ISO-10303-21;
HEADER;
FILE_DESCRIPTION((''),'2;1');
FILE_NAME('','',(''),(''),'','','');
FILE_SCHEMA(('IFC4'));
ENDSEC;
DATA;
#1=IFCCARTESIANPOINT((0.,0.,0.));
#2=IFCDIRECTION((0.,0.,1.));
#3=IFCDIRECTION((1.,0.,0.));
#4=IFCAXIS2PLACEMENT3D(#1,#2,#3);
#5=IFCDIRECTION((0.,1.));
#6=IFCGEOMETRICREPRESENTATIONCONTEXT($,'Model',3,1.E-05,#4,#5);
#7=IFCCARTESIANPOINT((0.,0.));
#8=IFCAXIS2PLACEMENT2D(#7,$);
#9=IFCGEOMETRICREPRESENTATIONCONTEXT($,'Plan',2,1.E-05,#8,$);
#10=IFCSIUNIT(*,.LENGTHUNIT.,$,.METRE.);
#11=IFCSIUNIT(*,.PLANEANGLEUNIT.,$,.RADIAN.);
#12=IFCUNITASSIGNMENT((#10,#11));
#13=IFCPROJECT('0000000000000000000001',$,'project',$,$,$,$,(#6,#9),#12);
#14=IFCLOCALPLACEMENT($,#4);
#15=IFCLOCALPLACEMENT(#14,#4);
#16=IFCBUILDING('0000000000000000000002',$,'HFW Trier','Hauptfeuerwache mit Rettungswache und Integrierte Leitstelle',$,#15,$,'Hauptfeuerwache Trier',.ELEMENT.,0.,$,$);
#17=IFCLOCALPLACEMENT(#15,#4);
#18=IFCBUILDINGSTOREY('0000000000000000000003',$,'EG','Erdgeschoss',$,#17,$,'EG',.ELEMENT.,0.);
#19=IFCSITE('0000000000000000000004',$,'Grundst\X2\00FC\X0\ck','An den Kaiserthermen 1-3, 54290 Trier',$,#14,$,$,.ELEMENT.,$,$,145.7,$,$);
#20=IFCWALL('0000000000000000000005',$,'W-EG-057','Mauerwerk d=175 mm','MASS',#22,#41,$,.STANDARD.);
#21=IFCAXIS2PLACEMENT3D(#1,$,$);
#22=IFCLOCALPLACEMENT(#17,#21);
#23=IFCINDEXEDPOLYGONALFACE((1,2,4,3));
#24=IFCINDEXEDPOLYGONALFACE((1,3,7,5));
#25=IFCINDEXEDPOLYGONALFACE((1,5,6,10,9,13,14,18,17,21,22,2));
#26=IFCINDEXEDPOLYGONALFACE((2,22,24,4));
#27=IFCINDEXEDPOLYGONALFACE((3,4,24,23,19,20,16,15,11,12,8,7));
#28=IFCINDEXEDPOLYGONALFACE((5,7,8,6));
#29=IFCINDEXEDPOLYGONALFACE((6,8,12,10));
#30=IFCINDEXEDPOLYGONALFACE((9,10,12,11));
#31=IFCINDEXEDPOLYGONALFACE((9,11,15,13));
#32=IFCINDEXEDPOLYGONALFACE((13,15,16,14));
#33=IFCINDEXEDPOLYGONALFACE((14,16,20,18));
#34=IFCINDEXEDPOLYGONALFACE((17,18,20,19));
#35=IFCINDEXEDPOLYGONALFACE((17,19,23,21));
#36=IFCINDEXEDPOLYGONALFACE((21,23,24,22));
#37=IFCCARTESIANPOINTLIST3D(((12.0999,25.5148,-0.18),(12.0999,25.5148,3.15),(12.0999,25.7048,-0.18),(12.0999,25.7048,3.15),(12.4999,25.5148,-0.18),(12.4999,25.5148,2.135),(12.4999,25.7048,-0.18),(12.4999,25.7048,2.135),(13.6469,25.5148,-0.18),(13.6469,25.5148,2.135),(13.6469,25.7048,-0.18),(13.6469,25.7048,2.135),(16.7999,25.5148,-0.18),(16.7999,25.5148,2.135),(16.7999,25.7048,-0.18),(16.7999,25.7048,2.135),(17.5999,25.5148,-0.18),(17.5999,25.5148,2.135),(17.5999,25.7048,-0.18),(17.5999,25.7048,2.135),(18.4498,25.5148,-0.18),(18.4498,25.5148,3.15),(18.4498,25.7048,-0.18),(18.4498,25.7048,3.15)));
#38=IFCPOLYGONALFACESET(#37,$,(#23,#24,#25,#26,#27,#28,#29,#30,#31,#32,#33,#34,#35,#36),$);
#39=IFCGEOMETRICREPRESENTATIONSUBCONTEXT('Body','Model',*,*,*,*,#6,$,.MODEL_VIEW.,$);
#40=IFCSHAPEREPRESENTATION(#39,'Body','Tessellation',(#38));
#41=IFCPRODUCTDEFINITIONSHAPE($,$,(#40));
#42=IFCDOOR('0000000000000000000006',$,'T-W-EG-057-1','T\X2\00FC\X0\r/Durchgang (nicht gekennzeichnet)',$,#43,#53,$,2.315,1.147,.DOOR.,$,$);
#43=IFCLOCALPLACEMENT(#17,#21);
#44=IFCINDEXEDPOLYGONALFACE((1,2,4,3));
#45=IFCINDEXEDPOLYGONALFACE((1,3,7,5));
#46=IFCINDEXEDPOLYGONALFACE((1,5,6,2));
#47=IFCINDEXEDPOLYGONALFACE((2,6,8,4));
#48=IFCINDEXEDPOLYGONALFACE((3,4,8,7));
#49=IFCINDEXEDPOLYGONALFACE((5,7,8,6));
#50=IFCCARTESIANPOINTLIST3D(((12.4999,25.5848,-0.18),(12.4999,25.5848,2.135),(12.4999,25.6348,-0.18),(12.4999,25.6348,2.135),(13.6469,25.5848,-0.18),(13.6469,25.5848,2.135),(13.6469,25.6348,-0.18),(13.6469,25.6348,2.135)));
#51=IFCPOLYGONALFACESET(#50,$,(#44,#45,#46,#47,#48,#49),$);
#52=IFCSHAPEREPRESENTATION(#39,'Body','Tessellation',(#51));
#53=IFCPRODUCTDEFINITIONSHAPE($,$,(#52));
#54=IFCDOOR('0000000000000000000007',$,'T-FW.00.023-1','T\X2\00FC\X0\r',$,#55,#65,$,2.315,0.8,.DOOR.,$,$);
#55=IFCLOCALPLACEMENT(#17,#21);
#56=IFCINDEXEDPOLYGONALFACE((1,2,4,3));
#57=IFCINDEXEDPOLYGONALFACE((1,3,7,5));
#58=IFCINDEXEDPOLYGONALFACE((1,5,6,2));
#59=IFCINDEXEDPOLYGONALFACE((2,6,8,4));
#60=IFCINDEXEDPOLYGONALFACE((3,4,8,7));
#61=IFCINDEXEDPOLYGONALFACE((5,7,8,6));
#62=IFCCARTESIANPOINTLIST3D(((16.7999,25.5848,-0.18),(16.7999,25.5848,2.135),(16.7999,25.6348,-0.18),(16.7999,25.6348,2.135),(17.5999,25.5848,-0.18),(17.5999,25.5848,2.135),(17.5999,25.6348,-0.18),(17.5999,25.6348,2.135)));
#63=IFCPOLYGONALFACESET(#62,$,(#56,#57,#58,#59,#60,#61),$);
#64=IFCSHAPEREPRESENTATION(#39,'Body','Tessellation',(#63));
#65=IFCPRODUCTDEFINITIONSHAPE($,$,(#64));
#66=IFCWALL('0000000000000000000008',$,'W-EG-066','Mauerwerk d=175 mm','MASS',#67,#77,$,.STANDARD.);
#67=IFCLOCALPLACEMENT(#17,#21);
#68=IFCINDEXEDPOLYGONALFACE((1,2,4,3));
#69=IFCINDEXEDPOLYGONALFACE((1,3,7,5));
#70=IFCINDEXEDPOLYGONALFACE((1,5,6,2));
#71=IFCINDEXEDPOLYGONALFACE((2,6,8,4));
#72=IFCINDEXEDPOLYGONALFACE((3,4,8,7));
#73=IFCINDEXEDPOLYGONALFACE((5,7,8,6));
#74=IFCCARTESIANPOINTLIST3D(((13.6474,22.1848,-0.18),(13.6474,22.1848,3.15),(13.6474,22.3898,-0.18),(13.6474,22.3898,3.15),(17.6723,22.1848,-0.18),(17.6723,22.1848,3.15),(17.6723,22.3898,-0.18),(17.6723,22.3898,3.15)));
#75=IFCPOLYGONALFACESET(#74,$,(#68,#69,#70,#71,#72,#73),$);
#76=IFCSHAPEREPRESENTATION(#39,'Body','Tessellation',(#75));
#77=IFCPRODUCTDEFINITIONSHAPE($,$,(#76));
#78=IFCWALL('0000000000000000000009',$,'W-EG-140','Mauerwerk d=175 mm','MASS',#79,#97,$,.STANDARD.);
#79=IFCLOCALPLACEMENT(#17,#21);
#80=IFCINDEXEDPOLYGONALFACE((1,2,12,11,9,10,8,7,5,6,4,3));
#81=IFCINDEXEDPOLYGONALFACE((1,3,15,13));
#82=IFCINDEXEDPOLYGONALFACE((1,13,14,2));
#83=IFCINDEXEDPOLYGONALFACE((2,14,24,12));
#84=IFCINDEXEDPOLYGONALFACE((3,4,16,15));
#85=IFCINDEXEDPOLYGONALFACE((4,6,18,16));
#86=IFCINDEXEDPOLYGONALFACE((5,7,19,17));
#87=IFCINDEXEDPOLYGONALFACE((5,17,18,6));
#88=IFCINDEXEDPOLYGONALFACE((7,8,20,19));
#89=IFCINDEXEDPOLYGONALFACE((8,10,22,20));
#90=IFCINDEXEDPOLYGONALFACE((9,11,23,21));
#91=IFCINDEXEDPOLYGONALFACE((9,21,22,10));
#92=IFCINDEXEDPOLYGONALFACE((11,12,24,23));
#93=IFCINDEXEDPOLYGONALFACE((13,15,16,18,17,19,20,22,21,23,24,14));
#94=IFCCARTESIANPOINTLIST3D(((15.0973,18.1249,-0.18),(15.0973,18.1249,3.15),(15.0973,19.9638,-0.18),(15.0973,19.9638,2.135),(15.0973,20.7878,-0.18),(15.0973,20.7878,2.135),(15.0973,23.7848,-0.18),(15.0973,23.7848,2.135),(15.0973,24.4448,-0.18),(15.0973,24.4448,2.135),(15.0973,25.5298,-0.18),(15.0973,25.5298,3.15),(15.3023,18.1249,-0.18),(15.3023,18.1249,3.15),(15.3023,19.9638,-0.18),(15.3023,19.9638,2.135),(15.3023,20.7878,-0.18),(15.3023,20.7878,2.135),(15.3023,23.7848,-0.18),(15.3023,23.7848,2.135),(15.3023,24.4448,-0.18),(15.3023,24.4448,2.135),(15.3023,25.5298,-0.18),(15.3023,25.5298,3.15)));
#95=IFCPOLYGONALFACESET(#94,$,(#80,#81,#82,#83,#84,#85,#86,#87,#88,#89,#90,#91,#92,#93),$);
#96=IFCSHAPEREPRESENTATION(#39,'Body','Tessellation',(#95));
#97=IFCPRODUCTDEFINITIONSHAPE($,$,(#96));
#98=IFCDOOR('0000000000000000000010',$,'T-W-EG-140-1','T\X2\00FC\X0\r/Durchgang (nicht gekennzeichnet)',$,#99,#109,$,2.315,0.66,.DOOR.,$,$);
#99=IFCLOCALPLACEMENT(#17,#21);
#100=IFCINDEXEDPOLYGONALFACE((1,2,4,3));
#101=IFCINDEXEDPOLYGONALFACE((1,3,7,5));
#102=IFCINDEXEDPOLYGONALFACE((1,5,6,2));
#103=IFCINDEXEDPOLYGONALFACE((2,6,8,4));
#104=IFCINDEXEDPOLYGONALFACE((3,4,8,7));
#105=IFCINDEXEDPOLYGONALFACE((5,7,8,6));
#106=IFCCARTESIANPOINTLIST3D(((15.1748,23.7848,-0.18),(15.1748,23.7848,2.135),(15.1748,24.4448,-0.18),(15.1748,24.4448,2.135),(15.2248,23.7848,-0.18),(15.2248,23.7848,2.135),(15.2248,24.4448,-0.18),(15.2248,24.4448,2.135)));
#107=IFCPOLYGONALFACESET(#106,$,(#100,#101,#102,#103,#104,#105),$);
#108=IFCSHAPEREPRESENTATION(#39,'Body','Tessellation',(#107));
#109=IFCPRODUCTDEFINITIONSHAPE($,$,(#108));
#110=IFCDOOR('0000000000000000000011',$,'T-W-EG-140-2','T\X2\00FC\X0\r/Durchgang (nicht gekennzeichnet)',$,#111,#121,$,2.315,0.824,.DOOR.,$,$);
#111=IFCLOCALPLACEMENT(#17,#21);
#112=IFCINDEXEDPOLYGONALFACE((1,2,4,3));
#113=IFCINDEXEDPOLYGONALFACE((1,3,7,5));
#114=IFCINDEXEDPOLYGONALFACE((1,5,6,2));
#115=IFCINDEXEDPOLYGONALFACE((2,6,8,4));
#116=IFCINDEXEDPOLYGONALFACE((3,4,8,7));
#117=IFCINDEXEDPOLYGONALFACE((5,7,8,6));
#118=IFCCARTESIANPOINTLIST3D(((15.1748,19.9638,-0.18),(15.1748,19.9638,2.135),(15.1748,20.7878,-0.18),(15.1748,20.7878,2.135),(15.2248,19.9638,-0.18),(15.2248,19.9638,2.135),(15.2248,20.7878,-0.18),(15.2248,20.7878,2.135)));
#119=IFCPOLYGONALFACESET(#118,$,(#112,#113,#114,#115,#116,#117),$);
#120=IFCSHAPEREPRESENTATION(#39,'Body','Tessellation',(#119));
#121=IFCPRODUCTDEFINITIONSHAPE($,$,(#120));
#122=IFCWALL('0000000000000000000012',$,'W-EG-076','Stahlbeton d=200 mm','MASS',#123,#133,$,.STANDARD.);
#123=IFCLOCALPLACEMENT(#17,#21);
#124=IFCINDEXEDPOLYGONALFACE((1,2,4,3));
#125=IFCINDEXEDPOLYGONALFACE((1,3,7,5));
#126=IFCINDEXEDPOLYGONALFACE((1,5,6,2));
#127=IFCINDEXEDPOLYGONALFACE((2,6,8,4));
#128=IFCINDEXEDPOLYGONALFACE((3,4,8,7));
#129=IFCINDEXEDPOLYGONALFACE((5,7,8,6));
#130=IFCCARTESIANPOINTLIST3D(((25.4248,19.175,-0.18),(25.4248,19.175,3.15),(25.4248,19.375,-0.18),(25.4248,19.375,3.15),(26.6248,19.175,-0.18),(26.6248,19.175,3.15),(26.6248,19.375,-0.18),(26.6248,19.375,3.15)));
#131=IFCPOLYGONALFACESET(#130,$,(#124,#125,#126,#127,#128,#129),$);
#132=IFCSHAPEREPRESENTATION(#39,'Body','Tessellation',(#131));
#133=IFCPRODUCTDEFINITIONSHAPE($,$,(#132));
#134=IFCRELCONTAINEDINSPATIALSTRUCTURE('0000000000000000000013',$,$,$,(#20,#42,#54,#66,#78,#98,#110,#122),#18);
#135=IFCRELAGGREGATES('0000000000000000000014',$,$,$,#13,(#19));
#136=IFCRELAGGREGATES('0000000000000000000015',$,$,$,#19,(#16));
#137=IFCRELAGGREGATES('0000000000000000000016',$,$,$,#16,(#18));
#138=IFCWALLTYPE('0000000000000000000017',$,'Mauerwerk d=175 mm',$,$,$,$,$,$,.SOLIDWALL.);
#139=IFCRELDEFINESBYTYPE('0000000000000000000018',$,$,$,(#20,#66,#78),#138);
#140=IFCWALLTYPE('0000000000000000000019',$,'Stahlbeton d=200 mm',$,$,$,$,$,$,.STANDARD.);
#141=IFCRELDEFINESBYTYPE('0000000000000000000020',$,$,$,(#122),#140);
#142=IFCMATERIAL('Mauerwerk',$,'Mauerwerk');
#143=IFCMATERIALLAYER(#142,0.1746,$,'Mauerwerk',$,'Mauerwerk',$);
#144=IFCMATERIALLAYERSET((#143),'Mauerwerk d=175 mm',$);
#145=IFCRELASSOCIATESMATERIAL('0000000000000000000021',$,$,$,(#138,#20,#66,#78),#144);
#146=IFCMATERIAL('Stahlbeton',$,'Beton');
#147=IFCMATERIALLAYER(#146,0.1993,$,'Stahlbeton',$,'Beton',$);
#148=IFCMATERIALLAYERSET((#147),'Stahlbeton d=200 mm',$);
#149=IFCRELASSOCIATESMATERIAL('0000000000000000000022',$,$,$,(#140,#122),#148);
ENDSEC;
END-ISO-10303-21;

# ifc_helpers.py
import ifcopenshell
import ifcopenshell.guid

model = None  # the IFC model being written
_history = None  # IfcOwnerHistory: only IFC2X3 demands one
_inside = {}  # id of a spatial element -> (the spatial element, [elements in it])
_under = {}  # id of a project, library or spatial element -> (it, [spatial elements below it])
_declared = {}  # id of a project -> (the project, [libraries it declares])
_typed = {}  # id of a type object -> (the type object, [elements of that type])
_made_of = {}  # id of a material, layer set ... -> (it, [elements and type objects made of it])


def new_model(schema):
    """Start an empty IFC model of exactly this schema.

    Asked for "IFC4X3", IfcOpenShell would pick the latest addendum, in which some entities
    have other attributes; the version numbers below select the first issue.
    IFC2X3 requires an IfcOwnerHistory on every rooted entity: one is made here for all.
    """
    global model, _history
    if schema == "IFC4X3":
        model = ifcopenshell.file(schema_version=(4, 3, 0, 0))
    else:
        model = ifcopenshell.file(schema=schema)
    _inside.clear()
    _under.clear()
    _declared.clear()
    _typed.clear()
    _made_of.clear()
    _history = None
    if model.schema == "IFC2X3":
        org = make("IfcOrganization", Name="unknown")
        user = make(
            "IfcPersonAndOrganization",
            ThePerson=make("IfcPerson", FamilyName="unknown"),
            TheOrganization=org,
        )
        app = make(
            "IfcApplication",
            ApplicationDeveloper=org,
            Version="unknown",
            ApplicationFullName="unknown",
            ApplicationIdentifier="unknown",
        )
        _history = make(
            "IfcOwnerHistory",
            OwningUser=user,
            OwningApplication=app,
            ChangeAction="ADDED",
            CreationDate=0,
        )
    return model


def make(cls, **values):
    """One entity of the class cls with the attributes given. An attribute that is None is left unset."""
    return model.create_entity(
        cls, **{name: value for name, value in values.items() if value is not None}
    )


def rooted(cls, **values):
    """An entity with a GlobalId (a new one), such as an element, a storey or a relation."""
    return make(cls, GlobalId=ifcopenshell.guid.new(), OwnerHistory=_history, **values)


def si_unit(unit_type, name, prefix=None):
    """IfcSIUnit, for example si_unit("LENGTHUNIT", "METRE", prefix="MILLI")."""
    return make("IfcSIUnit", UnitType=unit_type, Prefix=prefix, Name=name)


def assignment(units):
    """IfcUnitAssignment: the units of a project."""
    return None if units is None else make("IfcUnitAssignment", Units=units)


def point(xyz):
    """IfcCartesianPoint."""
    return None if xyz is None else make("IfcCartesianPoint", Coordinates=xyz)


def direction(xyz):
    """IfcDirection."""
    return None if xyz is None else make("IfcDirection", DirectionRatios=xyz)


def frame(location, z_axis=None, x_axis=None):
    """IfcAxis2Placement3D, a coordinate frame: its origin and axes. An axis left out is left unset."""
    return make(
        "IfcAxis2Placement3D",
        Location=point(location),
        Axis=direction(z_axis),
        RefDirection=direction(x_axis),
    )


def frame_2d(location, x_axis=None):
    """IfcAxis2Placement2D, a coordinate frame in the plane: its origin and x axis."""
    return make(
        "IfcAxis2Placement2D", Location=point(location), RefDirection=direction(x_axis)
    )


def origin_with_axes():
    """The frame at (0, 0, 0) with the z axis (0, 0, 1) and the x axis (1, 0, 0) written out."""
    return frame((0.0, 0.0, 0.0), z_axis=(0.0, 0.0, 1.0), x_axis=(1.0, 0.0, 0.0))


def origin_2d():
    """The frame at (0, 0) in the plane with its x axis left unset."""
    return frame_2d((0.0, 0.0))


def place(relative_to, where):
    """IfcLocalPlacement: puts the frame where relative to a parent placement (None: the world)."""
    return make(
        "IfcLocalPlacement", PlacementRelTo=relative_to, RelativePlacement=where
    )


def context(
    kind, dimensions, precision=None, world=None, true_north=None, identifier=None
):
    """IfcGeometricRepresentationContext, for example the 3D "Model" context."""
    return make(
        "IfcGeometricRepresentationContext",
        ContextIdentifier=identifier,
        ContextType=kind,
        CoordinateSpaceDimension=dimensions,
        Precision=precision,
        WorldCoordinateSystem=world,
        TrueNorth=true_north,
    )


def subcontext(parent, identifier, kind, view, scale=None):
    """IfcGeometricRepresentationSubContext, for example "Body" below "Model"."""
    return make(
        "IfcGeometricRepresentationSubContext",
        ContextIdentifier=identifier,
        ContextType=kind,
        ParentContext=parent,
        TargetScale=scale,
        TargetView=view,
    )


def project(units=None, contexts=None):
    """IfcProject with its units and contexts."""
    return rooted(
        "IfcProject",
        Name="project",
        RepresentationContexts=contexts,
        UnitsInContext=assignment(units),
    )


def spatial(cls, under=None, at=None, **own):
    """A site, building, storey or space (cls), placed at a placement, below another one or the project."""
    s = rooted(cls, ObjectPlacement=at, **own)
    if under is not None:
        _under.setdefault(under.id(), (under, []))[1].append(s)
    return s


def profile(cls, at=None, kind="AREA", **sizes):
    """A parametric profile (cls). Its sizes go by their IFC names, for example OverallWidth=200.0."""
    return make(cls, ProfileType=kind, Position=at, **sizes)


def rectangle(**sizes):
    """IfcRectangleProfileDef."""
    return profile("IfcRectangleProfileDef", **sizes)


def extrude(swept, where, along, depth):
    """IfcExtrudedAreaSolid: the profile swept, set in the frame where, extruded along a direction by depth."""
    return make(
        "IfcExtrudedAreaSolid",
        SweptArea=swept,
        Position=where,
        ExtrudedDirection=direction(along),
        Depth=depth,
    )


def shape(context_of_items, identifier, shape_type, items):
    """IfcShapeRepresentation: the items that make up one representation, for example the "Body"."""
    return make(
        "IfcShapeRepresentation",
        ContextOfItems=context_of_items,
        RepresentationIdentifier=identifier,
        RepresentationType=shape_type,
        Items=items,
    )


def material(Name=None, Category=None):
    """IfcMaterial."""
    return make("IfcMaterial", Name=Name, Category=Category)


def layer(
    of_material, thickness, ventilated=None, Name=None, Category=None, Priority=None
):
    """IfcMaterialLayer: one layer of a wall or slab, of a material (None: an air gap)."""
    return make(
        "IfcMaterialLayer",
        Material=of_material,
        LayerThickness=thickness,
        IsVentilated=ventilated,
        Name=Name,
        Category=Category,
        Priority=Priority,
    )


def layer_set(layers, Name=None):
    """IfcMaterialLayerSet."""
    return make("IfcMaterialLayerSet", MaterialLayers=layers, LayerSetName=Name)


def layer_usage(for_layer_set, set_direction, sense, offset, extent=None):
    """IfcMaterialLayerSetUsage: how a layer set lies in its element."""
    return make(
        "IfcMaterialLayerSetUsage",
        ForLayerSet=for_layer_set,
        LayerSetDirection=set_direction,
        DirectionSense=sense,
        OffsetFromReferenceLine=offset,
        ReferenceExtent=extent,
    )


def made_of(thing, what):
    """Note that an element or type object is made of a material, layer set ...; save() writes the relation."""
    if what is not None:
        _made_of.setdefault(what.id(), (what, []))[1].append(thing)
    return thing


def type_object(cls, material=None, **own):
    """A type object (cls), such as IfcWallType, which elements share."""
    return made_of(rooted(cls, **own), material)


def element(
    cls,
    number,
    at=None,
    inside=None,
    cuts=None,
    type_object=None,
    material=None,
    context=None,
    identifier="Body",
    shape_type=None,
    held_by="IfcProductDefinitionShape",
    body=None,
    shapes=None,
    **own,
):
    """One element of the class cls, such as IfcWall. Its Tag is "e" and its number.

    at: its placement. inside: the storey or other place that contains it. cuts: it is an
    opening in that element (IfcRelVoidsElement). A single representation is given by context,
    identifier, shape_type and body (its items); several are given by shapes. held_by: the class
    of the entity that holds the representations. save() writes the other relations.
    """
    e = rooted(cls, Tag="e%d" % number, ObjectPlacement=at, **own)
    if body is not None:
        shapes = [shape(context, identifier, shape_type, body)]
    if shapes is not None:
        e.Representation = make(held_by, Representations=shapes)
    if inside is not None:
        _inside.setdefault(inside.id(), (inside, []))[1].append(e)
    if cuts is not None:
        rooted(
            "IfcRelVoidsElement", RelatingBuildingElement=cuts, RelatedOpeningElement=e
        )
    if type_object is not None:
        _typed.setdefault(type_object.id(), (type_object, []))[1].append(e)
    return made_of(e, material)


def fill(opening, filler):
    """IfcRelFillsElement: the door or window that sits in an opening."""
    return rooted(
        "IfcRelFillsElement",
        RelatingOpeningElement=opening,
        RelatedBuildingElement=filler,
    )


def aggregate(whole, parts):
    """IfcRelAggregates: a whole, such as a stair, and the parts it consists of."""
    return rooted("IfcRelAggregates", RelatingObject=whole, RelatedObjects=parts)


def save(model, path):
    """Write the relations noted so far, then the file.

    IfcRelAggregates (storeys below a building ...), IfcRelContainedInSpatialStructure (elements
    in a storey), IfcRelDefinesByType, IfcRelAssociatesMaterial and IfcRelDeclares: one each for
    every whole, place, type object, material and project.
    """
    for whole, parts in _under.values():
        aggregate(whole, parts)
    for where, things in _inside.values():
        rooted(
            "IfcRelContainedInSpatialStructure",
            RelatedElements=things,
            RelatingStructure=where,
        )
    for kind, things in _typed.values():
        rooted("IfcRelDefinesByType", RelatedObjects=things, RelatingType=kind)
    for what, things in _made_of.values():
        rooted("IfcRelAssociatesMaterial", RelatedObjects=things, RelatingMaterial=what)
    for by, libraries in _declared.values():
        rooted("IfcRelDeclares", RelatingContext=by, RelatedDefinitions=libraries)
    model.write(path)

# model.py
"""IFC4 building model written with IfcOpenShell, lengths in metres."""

from ifc_helpers import new_model, si_unit, direction, frame, frame_2d, origin_with_axes, origin_2d, place, context, subcontext, project, spatial, rectangle, extrude, material, layer, layer_set, layer_usage, type_object, element, fill, save


model = new_model("IFC4")

# Units and contexts
model_context = context("Model", 3, precision=1e-05, world=origin_with_axes(), true_north=direction((0.0, 1.0)))
plan_context = context("Plan", 2, precision=1e-05, world=origin_2d())
body_context = subcontext(model_context, "Body", "Model", "MODEL_VIEW")
ifc_project = project(units=[si_unit("LENGTHUNIT", "METRE"), si_unit("PLANEANGLEUNIT", "RADIAN")], contexts=[model_context, plan_context])

# Site, building, storey
site_placement = place(None, origin_with_axes())
site = spatial("IfcSite", under=ifc_project, at=site_placement, Name="Grundstück", Description="An den Kaiserthermen 1-3, 54290 Trier", CompositionType="ELEMENT", RefElevation=145.7)
building_placement = place(site_placement, origin_with_axes())
building = spatial("IfcBuilding", under=site, at=building_placement, Name="HFW Trier", Description="Hauptfeuerwache mit Rettungswache und Integrierte Leitstelle", LongName="Hauptfeuerwache Trier", CompositionType="ELEMENT", ElevationOfRefHeight=0.0)
storey_placement = place(building_placement, origin_with_axes())
storey = spatial("IfcBuildingStorey", under=building, at=storey_placement, Name="EG", Description="Erdgeschoss", LongName="EG", CompositionType="ELEMENT", Elevation=0.0)

# Shared definitions
ifc_material_1 = material(Name="Stahlbeton", Category="Beton")

# Wall, openings, doors
ifc_material_2 = material(Name="Mauerwerk", Category="Mauerwerk")
ifc_layer_1 = layer(ifc_material_2, 0.1746, Name="Mauerwerk", Category="Mauerwerk")
ifc_layer_set_1 = layer_set([ifc_layer_1], Name="Mauerwerk d=175 mm")
ifc_layer_usage_1 = layer_usage(ifc_layer_set_1, "AXIS2", "POSITIVE", -0.095)
wall_type_1 = type_object("IfcWallType", Name="Mauerwerk d=175 mm", PredefinedType="SOLIDWALL", material=ifc_layer_set_1)
wall_1_placement = place(storey_placement, frame((12.0999, 25.6098, -0.18), z_axis=(0.0, 0.0, 1.0), x_axis=(1.0, 0.0, 0.0)))
wall_1 = element("IfcWall", 1, at=wall_1_placement, inside=storey, type_object=wall_type_1, material=ifc_layer_usage_1, Name="W-EG-057", Description="Mauerwerk d=175 mm", ObjectType="MASS", PredefinedType="STANDARD", context=body_context, shape_type="SweptSolid", body=[
    extrude(rectangle(XDim=6.3499, YDim=0.19, at=frame_2d((3.1749, 0.0))), origin_with_axes(), (0.0, 0.0, 1.0), 3.33),
])
opening_1_placement = place(wall_1_placement, frame((0.4, 0.0, 0.0), z_axis=(0.0, 0.0, 1.0), x_axis=(1.0, 0.0, 0.0)))
opening_1 = element("IfcOpeningElement", 2, at=opening_1_placement, cuts=wall_1, PredefinedType="OPENING", context=body_context, shape_type="SweptSolid", body=[
    extrude(rectangle(XDim=1.147, YDim=0.29, at=frame_2d((0.5735, 0.0))), origin_with_axes(), (0.0, 0.0, 1.0), 2.315),
])
opening_2_placement = place(wall_1_placement, frame((4.7, 0.0, 0.0), z_axis=(0.0, 0.0, 1.0), x_axis=(1.0, 0.0, 0.0)))
opening_2 = element("IfcOpeningElement", 3, at=opening_2_placement, cuts=wall_1, PredefinedType="OPENING", context=body_context, shape_type="SweptSolid", body=[
    extrude(rectangle(XDim=0.8, YDim=0.29, at=frame_2d((0.4, 0.0))), origin_with_axes(), (0.0, 0.0, 1.0), 2.315),
])
door_1_placement = place(wall_1_placement, frame((0.4, 0.0, 0.0), z_axis=(0.0, 0.0, 1.0), x_axis=(1.0, 0.0, 0.0)))
door_1 = element("IfcDoor", 4, at=door_1_placement, inside=storey, Name="T-W-EG-057-1", Description="Tür/Durchgang (nicht gekennzeichnet)", OverallHeight=2.315, OverallWidth=1.147, PredefinedType="DOOR", context=body_context, shape_type="SweptSolid", body=[
    extrude(rectangle(XDim=1.147, YDim=0.05, at=frame_2d((0.5735, 0.0))), origin_with_axes(), (0.0, 0.0, 1.0), 2.315),
])
fill(opening_1, door_1)
door_2_placement = place(wall_1_placement, frame((4.7, 0.0, 0.0), z_axis=(0.0, 0.0, 1.0), x_axis=(1.0, 0.0, 0.0)))
door_2 = element("IfcDoor", 5, at=door_2_placement, inside=storey, Name="T-FW.00.023-1", Description="Tür", OverallHeight=2.315, OverallWidth=0.8, PredefinedType="DOOR", context=body_context, shape_type="SweptSolid", body=[
    extrude(rectangle(XDim=0.8, YDim=0.05, at=frame_2d((0.4, 0.0))), origin_with_axes(), (0.0, 0.0, 1.0), 2.315),
])
fill(opening_2, door_2)

# Wall
ifc_layer_usage_2 = layer_usage(ifc_layer_set_1, "AXIS2", "POSITIVE", -0.1025)
wall_2_placement = place(storey_placement, frame((13.6474, 22.2873, -0.18), z_axis=(0.0, 0.0, 1.0), x_axis=(1.0, 0.0, 0.0)))
element("IfcWall", 6, at=wall_2_placement, inside=storey, type_object=wall_type_1, material=ifc_layer_usage_2, Name="W-EG-066", Description="Mauerwerk d=175 mm", ObjectType="MASS", PredefinedType="STANDARD", context=body_context, shape_type="SweptSolid", body=[
    extrude(rectangle(XDim=4.0249, YDim=0.205, at=frame_2d((2.0125, 0.0))), origin_with_axes(), (0.0, 0.0, 1.0), 3.33),
])

# Wall, openings, doors
ifc_layer_usage_3 = layer_usage(ifc_layer_set_1, "AXIS2", "POSITIVE", -0.1025)
wall_3_placement = place(storey_placement, frame((15.1998, 25.5298, -0.18), z_axis=(0.0, 0.0, 1.0), x_axis=(0.0, -1.0, 0.0)))
wall_3 = element("IfcWall", 7, at=wall_3_placement, inside=storey, type_object=wall_type_1, material=ifc_layer_usage_3, Name="W-EG-140", Description="Mauerwerk d=175 mm", ObjectType="MASS", PredefinedType="STANDARD", context=body_context, shape_type="SweptSolid", body=[
    extrude(rectangle(XDim=7.4049, YDim=0.205, at=frame_2d((3.7025, 0.0))), origin_with_axes(), (0.0, 0.0, 1.0), 3.33),
])
opening_3_placement = place(wall_3_placement, frame((1.085, 0.0, 0.0), z_axis=(0.0, 0.0, 1.0), x_axis=(1.0, 0.0, 0.0)))
opening_3 = element("IfcOpeningElement", 8, at=opening_3_placement, cuts=wall_3, PredefinedType="OPENING", context=body_context, shape_type="SweptSolid", body=[
    extrude(rectangle(XDim=0.66, YDim=0.305, at=frame_2d((0.33, 0.0))), origin_with_axes(), (0.0, 0.0, 1.0), 2.315),
])
opening_4_placement = place(wall_3_placement, frame((4.742, 0.0, 0.0), z_axis=(0.0, 0.0, 1.0), x_axis=(1.0, 0.0, 0.0)))
opening_4 = element("IfcOpeningElement", 9, at=opening_4_placement, cuts=wall_3, PredefinedType="OPENING", context=body_context, shape_type="SweptSolid", body=[
    extrude(rectangle(XDim=0.824, YDim=0.305, at=frame_2d((0.412, 0.0))), origin_with_axes(), (0.0, 0.0, 1.0), 2.315),
])
door_3_placement = place(wall_3_placement, frame((1.085, 0.0, 0.0), z_axis=(0.0, 0.0, 1.0), x_axis=(1.0, 0.0, 0.0)))
door_3 = element("IfcDoor", 10, at=door_3_placement, inside=storey, Name="T-W-EG-140-1", Description="Tür/Durchgang (nicht gekennzeichnet)", OverallHeight=2.315, OverallWidth=0.66, PredefinedType="DOOR", context=body_context, shape_type="SweptSolid", body=[
    extrude(rectangle(XDim=0.66, YDim=0.05, at=frame_2d((0.33, 0.0))), origin_with_axes(), (0.0, 0.0, 1.0), 2.315),
])
fill(opening_3, door_3)
door_4_placement = place(wall_3_placement, frame((4.742, 0.0, 0.0), z_axis=(0.0, 0.0, 1.0), x_axis=(1.0, 0.0, 0.0)))
door_4 = element("IfcDoor", 11, at=door_4_placement, inside=storey, Name="T-W-EG-140-2", Description="Tür/Durchgang (nicht gekennzeichnet)", OverallHeight=2.315, OverallWidth=0.824, PredefinedType="DOOR", context=body_context, shape_type="SweptSolid", body=[
    extrude(rectangle(XDim=0.824, YDim=0.05, at=frame_2d((0.412, 0.0))), origin_with_axes(), (0.0, 0.0, 1.0), 2.315),
])
fill(opening_4, door_4)

# Wall
ifc_layer_2 = layer(ifc_material_1, 0.1993, Name="Stahlbeton", Category="Beton")
ifc_layer_set_2 = layer_set([ifc_layer_2], Name="Stahlbeton d=200 mm")
ifc_layer_usage_4 = layer_usage(ifc_layer_set_2, "AXIS2", "POSITIVE", -0.1)
wall_type_2 = type_object("IfcWallType", Name="Stahlbeton d=200 mm", PredefinedType="STANDARD", material=ifc_layer_set_2)
wall_4_placement = place(storey_placement, frame((25.4248, 19.275, -0.18), z_axis=(0.0, 0.0, 1.0), x_axis=(1.0, 0.0, 0.0)))
element("IfcWall", 12, at=wall_4_placement, inside=storey, type_object=wall_type_2, material=ifc_layer_usage_4, Name="W-EG-076", Description="Stahlbeton d=200 mm", ObjectType="MASS", PredefinedType="STANDARD", context=body_context, shape_type="SweptSolid", body=[
    extrude(rectangle(XDim=1.2, YDim=0.2, at=frame_2d((0.6, 0.0))), origin_with_axes(), (0.0, 0.0, 1.0), 3.33),
])

save(model, "model.ifc")
